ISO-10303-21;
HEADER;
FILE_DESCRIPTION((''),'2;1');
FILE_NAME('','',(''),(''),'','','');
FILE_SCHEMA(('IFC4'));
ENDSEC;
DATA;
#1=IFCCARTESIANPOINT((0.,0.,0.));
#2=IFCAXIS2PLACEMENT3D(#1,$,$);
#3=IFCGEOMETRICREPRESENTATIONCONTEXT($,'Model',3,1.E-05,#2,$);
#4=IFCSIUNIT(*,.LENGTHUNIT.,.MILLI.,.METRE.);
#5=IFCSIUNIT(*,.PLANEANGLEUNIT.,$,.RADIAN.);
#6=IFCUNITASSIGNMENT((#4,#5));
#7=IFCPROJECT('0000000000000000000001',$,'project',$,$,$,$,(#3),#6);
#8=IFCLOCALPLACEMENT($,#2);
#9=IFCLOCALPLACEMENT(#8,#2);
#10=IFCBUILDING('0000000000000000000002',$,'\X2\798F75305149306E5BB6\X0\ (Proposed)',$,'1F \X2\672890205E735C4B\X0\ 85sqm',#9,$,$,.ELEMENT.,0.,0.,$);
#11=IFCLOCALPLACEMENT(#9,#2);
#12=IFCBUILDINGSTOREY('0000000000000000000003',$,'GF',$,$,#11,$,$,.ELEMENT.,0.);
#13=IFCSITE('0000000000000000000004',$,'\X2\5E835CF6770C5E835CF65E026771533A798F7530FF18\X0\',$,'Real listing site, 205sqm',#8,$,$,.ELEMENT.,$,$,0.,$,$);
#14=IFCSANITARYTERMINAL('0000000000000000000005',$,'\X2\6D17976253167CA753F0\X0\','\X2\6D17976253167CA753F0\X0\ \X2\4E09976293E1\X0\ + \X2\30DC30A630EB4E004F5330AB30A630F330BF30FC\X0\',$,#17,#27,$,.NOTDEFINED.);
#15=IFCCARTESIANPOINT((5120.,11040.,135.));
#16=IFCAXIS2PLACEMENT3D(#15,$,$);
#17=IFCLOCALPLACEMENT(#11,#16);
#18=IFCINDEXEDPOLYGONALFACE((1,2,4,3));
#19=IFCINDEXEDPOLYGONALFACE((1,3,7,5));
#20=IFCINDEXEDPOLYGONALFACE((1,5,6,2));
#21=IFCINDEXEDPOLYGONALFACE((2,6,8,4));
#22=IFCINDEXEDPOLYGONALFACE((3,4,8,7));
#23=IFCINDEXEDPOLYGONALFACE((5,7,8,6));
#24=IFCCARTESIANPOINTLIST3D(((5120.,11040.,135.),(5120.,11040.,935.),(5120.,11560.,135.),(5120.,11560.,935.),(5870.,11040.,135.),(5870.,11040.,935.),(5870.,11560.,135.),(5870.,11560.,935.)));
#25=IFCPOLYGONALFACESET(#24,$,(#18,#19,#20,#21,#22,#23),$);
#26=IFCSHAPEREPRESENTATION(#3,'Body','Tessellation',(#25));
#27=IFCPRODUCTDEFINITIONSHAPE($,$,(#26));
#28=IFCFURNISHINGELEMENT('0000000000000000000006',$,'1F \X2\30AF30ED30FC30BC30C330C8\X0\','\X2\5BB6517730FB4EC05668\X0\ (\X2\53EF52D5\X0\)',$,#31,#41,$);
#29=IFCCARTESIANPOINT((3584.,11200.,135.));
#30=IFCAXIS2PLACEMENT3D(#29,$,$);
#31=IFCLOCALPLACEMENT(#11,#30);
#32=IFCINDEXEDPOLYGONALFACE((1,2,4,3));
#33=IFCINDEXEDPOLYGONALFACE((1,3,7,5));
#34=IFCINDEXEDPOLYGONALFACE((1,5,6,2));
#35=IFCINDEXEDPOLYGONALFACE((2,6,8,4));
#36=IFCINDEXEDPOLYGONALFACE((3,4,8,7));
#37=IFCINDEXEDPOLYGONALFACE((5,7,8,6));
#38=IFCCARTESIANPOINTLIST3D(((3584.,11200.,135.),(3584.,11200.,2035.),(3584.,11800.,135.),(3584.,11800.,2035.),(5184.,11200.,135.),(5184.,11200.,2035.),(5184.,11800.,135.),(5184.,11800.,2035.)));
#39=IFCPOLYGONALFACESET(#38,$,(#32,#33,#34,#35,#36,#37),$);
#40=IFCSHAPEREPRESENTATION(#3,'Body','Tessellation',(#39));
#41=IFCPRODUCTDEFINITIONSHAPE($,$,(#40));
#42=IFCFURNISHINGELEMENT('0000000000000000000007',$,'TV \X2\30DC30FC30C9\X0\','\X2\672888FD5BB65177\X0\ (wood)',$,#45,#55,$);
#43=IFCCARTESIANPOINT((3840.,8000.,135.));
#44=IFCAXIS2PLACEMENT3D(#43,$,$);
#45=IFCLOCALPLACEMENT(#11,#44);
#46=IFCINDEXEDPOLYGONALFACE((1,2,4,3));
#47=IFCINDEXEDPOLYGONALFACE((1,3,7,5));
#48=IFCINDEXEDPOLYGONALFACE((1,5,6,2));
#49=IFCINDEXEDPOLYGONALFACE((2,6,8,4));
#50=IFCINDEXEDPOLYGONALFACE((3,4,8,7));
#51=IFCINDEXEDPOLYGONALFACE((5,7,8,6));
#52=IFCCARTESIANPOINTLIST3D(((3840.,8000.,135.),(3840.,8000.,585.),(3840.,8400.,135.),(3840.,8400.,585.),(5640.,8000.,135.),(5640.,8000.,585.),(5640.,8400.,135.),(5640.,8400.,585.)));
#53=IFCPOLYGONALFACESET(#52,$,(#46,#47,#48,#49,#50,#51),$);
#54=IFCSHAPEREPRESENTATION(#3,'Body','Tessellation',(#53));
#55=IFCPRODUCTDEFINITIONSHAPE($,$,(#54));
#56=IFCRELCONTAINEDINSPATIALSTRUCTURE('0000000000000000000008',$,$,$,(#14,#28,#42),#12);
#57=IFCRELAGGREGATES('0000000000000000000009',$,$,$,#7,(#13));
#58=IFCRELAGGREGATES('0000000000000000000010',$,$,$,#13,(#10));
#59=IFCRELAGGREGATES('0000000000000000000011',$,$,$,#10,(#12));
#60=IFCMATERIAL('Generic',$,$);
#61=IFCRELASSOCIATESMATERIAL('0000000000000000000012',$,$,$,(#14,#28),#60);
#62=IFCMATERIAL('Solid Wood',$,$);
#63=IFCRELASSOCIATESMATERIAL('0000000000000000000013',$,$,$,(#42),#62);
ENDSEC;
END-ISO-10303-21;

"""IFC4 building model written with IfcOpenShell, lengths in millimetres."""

from ifc_helpers import new_model, si_unit, frame, frame_2d, origin, place, context, project, spatial, rectangle, extrude, material, element, save


model = new_model("IFC4")

# Units and contexts
model_context = context("Model", 3, precision=1e-05, world=origin())
ifc_project = project(units=[si_unit("LENGTHUNIT", "METRE", prefix="MILLI"), si_unit("PLANEANGLEUNIT", "RADIAN")], contexts=[model_context])

# Site, building, storey
site_placement = place(None, origin())
site = spatial("IfcSite", under=ifc_project, at=site_placement, Name="広島県広島市東区福田８", ObjectType="Real listing site, 205sqm", CompositionType="ELEMENT", RefElevation=0.0)
building_placement = place(site_placement, origin())
building = spatial("IfcBuilding", under=site, at=building_placement, Name="福田光の家 (Proposed)", ObjectType="1F 木造平屋 85sqm", CompositionType="ELEMENT", ElevationOfRefHeight=0.0, ElevationOfTerrain=0.0)
storey_placement = place(building_placement, origin())
storey = spatial("IfcBuildingStorey", under=building, at=storey_placement, Name="GF", CompositionType="ELEMENT", Elevation=0.0)

# Shared definitions
ifc_material_1 = material(Name="Solid Wood")

# Shared definitions
ifc_material_2 = material(Name="Generic")

# Sanitary terminal
sanitary_terminal_1_placement = place(storey_placement, frame((5120.0, 11040.0, 135.0)))
element("IfcSanitaryTerminal", 1, at=sanitary_terminal_1_placement, inside=storey, material=ifc_material_2, Name="洗面化粧台", Description="洗面化粧台 三面鏡 + ボウル一体カウンター", PredefinedType="NOTDEFINED", context=model_context, shape_type="SweptSolid", body=[
    extrude(rectangle(XDim=750.0, YDim=520.0, at=frame_2d((375.0, 260.0))), frame((5120.0, 11040.0, 135.0)), (0.0, 0.0, 1.0), 800.0),
])

# Furnishing elements
furnishing_1_placement = place(storey_placement, frame((3584.0, 11200.0, 135.0)))
element("IfcFurnishingElement", 2, at=furnishing_1_placement, inside=storey, material=ifc_material_2, Name="1F クローゼット", Description="家具・什器 (可動)", context=model_context, shape_type="SweptSolid", body=[
    extrude(rectangle(XDim=1600.0, YDim=600.0, at=frame_2d((800.0, 300.0))), frame((3584.0, 11200.0, 135.0)), (0.0, 0.0, 1.0), 1900.0),
])
furnishing_2_placement = place(storey_placement, frame((3840.0, 8000.0, 135.0)))
element("IfcFurnishingElement", 3, at=furnishing_2_placement, inside=storey, material=ifc_material_1, Name="TV ボード", Description="木製家具 (wood)", context=model_context, shape_type="SweptSolid", body=[
    extrude(rectangle(XDim=1800.0, YDim=400.0, at=frame_2d((900.0, 200.0))), frame((3840.0, 8000.0, 135.0)), (0.0, 0.0, 1.0), 450.0),
])

save(model, "model.ifc")
